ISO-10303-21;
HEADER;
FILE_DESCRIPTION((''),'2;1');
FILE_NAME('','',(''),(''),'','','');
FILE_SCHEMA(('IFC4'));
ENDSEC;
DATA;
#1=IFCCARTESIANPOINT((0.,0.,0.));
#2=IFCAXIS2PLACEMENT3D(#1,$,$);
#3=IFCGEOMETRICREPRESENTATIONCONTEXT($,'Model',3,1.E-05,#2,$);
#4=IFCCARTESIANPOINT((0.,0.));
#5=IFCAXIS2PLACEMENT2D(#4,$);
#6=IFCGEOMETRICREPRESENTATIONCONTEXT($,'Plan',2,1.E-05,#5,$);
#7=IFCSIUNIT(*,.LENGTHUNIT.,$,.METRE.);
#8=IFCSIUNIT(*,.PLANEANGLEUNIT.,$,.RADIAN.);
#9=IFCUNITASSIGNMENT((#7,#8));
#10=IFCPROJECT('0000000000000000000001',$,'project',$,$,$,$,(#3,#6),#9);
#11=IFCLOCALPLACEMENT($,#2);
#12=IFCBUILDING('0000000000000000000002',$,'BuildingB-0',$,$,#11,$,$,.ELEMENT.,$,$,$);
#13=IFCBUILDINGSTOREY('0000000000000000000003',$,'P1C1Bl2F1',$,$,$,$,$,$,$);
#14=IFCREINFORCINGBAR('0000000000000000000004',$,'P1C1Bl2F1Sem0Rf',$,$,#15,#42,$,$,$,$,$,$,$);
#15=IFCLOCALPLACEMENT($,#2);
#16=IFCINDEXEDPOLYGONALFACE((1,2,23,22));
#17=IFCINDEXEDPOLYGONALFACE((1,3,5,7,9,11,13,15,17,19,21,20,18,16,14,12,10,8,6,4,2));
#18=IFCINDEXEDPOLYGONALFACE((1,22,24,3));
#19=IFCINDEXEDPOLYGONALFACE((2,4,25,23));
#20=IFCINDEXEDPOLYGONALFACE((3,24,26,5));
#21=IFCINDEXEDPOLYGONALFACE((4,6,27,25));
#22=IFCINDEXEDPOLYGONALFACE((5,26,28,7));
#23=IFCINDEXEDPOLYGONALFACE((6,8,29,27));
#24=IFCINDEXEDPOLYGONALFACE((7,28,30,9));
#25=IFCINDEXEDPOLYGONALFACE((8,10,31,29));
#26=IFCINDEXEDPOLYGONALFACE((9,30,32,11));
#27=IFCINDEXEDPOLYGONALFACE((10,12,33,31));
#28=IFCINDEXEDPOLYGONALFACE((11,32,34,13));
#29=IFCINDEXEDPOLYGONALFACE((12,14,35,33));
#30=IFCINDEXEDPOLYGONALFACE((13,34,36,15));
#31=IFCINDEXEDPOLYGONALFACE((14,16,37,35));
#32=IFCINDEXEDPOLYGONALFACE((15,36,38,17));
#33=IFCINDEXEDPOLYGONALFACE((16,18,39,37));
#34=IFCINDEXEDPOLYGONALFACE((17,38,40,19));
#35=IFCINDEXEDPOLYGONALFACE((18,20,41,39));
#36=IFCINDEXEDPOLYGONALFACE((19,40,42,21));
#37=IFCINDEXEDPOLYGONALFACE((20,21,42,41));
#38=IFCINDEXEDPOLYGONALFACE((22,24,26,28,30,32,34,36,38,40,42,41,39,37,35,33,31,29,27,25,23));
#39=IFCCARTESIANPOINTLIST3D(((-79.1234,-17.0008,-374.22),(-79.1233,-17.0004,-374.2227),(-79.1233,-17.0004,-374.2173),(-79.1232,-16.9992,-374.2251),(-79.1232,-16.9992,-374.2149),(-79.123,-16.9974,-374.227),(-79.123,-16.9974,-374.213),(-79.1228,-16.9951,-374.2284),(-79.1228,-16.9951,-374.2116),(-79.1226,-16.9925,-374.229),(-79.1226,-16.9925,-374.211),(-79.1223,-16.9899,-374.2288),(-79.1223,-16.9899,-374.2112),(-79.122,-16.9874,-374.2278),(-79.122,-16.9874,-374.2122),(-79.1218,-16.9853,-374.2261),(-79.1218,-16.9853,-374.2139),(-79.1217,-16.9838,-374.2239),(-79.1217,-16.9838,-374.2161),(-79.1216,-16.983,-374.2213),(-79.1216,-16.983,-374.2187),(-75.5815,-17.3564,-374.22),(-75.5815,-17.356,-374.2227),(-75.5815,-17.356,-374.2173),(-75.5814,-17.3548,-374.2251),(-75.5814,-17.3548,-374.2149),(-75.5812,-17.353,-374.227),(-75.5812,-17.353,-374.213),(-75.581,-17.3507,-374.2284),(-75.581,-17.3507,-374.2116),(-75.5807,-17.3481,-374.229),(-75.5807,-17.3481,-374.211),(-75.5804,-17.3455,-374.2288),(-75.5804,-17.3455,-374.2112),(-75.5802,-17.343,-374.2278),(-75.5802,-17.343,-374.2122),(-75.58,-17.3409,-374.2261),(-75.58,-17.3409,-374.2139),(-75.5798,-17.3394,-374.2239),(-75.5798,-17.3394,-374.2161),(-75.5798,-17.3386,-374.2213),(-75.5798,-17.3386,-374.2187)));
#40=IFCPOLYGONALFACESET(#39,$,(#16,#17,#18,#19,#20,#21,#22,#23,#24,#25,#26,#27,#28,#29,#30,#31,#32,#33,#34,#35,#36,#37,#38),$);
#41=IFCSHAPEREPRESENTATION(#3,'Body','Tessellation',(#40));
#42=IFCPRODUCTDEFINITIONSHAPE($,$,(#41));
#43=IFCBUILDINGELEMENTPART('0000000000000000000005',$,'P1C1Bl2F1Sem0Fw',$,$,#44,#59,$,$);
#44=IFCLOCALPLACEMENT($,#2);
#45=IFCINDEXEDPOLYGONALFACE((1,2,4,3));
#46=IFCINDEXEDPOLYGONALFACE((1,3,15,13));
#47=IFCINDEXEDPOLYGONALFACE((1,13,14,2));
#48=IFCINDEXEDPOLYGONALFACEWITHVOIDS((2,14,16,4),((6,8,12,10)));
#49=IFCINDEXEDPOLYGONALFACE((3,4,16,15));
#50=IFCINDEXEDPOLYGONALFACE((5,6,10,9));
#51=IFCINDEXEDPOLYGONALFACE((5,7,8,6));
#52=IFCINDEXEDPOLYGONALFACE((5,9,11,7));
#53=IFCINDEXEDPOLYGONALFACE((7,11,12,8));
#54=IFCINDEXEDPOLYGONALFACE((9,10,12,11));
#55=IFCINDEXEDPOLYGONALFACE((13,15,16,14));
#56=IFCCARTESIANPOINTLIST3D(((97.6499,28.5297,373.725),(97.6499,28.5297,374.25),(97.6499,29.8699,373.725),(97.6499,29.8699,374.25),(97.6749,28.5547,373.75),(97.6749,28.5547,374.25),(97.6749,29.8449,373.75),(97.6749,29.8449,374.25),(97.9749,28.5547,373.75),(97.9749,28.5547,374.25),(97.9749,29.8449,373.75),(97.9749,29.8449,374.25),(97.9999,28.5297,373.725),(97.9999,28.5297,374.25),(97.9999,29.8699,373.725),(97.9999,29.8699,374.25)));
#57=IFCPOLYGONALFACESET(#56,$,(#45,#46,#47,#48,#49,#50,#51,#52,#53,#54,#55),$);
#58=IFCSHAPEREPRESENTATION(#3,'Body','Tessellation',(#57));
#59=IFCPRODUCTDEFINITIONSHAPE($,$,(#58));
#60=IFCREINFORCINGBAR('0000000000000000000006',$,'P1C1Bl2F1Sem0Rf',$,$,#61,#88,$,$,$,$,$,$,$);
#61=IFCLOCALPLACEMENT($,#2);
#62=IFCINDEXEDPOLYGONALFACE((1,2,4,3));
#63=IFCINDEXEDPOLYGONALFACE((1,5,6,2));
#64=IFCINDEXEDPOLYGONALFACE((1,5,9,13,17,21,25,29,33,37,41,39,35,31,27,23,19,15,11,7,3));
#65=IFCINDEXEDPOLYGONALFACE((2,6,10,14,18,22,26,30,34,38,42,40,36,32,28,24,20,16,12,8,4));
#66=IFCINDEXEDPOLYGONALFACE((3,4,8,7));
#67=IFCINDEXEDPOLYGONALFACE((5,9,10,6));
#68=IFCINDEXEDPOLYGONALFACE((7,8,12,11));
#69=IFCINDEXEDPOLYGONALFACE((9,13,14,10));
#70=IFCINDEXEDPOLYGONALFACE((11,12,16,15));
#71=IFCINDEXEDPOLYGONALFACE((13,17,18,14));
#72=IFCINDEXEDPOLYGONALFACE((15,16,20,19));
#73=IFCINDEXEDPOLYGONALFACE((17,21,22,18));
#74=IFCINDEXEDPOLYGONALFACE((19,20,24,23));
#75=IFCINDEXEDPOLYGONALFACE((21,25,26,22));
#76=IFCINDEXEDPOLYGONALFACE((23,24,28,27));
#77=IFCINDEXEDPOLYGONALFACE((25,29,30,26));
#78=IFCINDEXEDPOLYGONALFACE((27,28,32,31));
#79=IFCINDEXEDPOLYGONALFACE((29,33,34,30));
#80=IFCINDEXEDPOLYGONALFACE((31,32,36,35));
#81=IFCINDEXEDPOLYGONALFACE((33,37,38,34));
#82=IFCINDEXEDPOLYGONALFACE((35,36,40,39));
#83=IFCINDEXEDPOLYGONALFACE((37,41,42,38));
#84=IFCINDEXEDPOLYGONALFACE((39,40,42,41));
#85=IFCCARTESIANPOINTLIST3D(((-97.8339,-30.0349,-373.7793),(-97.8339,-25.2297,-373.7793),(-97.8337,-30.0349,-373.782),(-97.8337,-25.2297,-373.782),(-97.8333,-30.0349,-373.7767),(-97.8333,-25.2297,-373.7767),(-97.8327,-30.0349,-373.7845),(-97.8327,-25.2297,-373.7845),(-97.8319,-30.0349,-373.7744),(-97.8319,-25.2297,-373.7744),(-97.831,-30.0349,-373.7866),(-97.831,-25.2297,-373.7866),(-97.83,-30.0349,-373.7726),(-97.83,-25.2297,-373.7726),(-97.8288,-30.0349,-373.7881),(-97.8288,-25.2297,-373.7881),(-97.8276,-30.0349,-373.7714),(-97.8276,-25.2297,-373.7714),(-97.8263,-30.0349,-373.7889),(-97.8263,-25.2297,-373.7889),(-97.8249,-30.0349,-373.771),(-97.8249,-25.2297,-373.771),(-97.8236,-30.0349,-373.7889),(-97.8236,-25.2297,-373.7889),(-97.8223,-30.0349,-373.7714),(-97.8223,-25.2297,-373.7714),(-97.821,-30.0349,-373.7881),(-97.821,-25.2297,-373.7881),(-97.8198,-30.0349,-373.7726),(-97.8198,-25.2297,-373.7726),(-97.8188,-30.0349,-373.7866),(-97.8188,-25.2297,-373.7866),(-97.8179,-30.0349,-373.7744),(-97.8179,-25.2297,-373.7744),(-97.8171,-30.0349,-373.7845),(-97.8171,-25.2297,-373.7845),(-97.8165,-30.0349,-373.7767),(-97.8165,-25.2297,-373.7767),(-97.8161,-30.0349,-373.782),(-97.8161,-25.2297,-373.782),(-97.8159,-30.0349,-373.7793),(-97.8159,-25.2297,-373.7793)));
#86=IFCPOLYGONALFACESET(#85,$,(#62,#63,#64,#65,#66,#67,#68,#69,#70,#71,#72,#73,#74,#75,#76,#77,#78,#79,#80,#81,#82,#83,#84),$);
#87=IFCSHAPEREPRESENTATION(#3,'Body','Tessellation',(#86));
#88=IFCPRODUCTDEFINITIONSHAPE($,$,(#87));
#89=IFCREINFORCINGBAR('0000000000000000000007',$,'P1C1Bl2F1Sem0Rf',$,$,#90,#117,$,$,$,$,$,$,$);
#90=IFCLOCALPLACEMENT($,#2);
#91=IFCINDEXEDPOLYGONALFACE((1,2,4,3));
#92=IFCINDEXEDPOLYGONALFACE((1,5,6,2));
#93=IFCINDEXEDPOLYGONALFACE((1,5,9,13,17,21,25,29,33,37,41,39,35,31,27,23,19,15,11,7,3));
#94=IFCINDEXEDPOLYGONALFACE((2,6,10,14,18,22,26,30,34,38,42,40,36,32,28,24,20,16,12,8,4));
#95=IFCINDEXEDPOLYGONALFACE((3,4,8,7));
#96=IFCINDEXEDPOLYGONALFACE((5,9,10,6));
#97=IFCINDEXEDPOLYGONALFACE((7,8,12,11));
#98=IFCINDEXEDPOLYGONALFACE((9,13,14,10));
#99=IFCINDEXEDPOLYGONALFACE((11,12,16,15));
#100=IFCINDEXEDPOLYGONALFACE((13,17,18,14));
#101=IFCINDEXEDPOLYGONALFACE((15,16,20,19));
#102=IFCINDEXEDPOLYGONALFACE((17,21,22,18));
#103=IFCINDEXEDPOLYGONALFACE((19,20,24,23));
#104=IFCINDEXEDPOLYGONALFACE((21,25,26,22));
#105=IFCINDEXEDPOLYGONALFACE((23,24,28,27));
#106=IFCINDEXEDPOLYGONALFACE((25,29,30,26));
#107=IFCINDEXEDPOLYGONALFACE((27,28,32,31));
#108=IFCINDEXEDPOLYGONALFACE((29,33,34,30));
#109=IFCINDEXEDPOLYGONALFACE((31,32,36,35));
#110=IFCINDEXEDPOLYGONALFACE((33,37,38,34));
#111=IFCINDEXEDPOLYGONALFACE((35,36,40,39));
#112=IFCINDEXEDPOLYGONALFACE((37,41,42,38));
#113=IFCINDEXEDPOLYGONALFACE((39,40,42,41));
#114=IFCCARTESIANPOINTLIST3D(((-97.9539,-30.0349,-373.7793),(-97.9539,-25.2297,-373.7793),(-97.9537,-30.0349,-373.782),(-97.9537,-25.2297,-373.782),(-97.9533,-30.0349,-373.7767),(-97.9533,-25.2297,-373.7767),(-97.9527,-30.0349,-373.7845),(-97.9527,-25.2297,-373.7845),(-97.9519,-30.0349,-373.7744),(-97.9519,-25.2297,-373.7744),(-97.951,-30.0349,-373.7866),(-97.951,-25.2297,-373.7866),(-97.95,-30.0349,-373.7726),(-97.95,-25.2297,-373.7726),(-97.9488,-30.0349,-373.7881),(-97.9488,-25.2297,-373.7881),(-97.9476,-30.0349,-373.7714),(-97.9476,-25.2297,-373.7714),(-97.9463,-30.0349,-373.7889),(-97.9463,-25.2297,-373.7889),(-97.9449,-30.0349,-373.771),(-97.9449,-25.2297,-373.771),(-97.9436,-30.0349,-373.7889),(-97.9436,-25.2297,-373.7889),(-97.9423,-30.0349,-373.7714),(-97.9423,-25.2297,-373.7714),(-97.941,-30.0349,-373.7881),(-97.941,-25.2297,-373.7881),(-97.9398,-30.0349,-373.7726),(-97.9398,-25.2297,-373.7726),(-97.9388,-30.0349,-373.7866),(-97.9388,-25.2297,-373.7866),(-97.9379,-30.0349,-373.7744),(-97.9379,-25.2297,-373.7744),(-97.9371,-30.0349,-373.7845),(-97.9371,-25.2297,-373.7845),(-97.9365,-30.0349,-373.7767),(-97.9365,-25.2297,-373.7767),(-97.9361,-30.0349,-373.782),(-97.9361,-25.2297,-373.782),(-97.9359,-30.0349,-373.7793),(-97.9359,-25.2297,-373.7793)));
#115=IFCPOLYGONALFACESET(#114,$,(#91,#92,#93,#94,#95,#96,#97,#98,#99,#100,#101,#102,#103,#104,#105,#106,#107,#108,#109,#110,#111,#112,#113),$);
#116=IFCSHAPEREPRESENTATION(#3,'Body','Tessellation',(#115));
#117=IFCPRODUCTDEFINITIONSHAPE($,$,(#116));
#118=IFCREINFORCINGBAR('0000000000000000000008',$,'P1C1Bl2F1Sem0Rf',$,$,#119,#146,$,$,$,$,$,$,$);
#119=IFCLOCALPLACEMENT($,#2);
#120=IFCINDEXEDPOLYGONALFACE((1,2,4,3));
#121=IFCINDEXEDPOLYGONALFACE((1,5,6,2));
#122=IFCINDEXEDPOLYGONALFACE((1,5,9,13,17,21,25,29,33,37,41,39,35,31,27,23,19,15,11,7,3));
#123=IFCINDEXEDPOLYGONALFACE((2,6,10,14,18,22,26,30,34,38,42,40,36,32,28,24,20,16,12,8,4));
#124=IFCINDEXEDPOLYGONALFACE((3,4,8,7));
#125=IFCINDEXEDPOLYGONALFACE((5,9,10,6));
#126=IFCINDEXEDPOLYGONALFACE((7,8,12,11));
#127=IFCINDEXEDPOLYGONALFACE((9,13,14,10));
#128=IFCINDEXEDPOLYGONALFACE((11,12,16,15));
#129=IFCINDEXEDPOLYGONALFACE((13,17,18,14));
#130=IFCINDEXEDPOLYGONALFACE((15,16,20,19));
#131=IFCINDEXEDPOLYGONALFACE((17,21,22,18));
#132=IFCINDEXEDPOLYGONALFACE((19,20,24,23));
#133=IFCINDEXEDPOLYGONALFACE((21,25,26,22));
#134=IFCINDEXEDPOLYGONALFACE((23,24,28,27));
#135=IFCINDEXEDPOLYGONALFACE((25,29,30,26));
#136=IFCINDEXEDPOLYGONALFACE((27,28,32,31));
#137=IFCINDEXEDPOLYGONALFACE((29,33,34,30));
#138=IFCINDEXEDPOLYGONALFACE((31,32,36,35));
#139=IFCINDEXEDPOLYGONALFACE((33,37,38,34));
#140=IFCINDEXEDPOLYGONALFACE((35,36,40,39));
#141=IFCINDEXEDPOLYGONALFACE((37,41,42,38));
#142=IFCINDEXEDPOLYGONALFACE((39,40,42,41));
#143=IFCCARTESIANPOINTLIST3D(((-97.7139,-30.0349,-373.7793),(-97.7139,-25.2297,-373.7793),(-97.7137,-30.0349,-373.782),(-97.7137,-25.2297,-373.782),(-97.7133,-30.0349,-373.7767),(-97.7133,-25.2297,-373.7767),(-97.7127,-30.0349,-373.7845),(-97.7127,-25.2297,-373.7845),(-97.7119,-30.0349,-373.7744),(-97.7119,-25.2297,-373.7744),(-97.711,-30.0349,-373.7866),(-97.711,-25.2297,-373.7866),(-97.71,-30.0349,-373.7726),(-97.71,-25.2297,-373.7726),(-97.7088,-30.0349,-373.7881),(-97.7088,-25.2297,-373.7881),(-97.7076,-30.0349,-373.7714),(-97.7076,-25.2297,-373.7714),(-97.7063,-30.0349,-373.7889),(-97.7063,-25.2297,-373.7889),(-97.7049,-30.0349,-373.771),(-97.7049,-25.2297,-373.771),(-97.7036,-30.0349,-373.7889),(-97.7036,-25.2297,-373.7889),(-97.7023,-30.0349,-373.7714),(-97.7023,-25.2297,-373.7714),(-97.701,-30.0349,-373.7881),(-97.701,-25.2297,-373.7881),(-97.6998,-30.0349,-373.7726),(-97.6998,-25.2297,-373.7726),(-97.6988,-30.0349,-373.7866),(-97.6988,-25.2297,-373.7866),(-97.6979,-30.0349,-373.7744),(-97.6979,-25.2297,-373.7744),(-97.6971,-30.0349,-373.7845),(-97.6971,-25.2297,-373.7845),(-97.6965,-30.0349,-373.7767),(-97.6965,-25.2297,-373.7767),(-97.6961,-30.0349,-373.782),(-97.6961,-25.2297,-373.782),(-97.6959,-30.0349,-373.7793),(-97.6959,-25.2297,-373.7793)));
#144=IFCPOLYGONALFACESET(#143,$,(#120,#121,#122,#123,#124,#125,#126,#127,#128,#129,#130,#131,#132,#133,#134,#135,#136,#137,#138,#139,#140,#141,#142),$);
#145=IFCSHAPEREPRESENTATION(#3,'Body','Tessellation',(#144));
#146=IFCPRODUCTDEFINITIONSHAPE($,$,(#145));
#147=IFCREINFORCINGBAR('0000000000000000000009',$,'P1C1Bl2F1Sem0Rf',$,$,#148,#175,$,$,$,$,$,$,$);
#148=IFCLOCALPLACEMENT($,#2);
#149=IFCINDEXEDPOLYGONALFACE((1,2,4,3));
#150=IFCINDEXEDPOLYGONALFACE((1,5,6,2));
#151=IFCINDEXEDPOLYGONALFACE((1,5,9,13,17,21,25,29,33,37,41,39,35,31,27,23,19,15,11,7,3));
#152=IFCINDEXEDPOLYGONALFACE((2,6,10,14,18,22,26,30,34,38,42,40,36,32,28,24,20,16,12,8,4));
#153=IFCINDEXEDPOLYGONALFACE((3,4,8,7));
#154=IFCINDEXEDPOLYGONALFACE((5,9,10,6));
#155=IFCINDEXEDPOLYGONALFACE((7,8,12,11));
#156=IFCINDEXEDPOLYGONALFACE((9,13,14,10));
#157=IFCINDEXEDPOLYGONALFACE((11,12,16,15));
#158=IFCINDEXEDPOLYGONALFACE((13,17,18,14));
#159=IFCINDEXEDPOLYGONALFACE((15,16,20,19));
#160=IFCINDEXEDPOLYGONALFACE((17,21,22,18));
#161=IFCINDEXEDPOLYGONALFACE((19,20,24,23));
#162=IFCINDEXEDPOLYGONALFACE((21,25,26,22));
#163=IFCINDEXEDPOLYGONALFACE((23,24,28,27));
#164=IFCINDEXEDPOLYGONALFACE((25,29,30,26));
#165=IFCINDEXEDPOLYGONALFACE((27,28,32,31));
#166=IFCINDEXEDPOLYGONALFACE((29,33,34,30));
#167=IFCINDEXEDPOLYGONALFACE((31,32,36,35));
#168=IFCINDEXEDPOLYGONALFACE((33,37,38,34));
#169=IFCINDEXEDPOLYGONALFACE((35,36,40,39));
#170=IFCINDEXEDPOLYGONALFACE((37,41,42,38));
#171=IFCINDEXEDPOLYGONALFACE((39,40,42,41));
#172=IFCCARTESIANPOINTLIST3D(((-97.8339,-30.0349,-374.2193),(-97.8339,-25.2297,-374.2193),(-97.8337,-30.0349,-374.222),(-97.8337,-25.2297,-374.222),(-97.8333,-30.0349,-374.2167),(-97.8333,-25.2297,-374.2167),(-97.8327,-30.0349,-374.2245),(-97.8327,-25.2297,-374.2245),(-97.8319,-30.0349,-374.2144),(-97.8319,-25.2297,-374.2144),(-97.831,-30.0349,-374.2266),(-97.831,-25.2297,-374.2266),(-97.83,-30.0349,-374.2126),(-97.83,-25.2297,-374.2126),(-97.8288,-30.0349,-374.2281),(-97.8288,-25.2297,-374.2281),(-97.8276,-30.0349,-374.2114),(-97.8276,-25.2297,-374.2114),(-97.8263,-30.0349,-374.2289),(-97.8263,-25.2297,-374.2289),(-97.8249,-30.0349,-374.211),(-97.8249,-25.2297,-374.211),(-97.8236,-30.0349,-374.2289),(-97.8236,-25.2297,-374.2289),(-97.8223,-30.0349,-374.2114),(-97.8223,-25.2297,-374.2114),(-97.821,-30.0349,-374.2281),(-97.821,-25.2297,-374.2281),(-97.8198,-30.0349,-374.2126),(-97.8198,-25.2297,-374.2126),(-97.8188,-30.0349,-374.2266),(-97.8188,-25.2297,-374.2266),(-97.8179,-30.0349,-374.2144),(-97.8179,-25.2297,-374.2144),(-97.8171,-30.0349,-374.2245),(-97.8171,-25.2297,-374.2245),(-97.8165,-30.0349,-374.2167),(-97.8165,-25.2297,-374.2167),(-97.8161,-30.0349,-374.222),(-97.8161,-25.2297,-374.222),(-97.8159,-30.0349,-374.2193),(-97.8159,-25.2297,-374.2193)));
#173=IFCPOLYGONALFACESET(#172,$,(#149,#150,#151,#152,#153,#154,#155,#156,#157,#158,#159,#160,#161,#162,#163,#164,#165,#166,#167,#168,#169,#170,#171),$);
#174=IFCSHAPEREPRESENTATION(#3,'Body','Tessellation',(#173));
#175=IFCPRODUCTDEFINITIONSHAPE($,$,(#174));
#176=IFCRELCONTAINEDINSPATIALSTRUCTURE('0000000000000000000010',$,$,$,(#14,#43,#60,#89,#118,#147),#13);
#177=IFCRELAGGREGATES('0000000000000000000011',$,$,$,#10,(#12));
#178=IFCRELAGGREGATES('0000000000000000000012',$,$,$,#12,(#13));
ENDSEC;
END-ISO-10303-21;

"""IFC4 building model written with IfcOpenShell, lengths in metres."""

from ifc_helpers import new_model, entity, si_unit, origin, origin_2d, place, context, project, spatial, polyline, outline, extrude, element, save


model = new_model("IFC4")

# Units and contexts
model_context = context("Model", 3, precision=1e-05, world=origin())
plan_context = context("Plan", 2, precision=1e-05, world=origin_2d())
ifc_project = project(units=[si_unit("LENGTHUNIT", "METRE"), si_unit("PLANEANGLEUNIT", "RADIAN")], contexts=[model_context, plan_context])

# Building, storey
building_placement = place(None, origin())
building = spatial("IfcBuilding", under=ifc_project, at=building_placement, Name="BuildingB-0", CompositionType="ELEMENT")
storey = spatial("IfcBuildingStorey", under=building, Name="P1C1Bl2F1")

# Reinforcing bar
element("IfcReinforcingBar", 1, inside=storey, Name="P1C1Bl2F1Sem0Rf", context=model_context, shape_type="SweptSolid", body=[
    entity("IfcSurfaceCurveSweptAreaSolid", entity("IfcCircleProfileDef", "AREA", None, None, 0.009), None, entity("IfcPolyline", [entity("IfcCartesianPoint", [79.1225, 16.9918, 374.22]), entity("IfcCartesianPoint", [75.5806, 17.3474, 374.22])]), None, None, entity("IfcPlane", entity("IfcAxis2Placement3D", entity("IfcCartesianPoint", [79.1225, 16.9918, 374.22]), entity("IfcDirection", [0.0, 0.0, 1.0]), entity("IfcDirection", [1.0, 0.0, 0.0])))),
])

# Building element part, opening
building_element_part_1 = element("IfcBuildingElementPart", 2, inside=storey, Name="P1C1Bl2F1Sem0Fw", context=model_context, shape_type="SweptSolid", body=[
    extrude(outline(polyline([(97.9999, 28.5297, 373.725), (97.6499, 28.5297, 373.725), (97.6499, 29.8699, 373.725), (97.9999, 29.8699, 373.725), (97.9999, 28.5297, 373.725)])), None, (0.0, 0.0, 1.0), 0.525),
])
element("IfcOpeningElement", 3, inside=storey, cuts=building_element_part_1, context=model_context, shape_type="SweptSolid", body=[
    extrude(outline(polyline([(97.9749, 28.5547, 373.75), (97.6749, 28.5547, 373.75), (97.6749, 29.8449, 373.75), (97.9749, 29.8449, 373.75), (97.9749, 28.5547, 373.75)])), None, (0.0, 0.0, 1.0), 0.5),
])

# Reinforcing bars
element("IfcReinforcingBar", 4, inside=storey, Name="P1C1Bl2F1Sem0Rf", context=model_context, shape_type="SweptSolid", body=[
    entity("IfcSurfaceCurveSweptAreaSolid", entity("IfcCircleProfileDef", "AREA", None, None, 0.009), None, entity("IfcPolyline", [entity("IfcCartesianPoint", [97.8249, 25.2297, 373.78]), entity("IfcCartesianPoint", [97.8249, 30.0349, 373.78])]), None, None, entity("IfcPlane", entity("IfcAxis2Placement3D", entity("IfcCartesianPoint", [97.8249, 25.2297, 373.78]), entity("IfcDirection", [0.0, 0.0, 1.0]), entity("IfcDirection", [1.0, 0.0, 0.0])))),
])
element("IfcReinforcingBar", 5, inside=storey, Name="P1C1Bl2F1Sem0Rf", context=model_context, shape_type="SweptSolid", body=[
    entity("IfcSurfaceCurveSweptAreaSolid", entity("IfcCircleProfileDef", "AREA", None, None, 0.009), None, entity("IfcPolyline", [entity("IfcCartesianPoint", [97.9449, 25.2297, 373.78]), entity("IfcCartesianPoint", [97.9449, 30.0349, 373.78])]), None, None, entity("IfcPlane", entity("IfcAxis2Placement3D", entity("IfcCartesianPoint", [97.9449, 25.2297, 373.78]), entity("IfcDirection", [0.0, 0.0, 1.0]), entity("IfcDirection", [1.0, 0.0, 0.0])))),
])
element("IfcReinforcingBar", 6, inside=storey, Name="P1C1Bl2F1Sem0Rf", context=model_context, shape_type="SweptSolid", body=[
    entity("IfcSurfaceCurveSweptAreaSolid", entity("IfcCircleProfileDef", "AREA", None, None, 0.009), None, entity("IfcPolyline", [entity("IfcCartesianPoint", [97.7049, 25.2297, 373.78]), entity("IfcCartesianPoint", [97.7049, 30.0349, 373.78])]), None, None, entity("IfcPlane", entity("IfcAxis2Placement3D", entity("IfcCartesianPoint", [97.7049, 25.2297, 373.78]), entity("IfcDirection", [0.0, 0.0, 1.0]), entity("IfcDirection", [1.0, 0.0, 0.0])))),
])
element("IfcReinforcingBar", 7, inside=storey, Name="P1C1Bl2F1Sem0Rf", context=model_context, shape_type="SweptSolid", body=[
    entity("IfcSurfaceCurveSweptAreaSolid", entity("IfcCircleProfileDef", "AREA", None, None, 0.009), None, entity("IfcPolyline", [entity("IfcCartesianPoint", [97.8249, 25.2297, 374.22]), entity("IfcCartesianPoint", [97.8249, 30.0349, 374.22])]), None, None, entity("IfcPlane", entity("IfcAxis2Placement3D", entity("IfcCartesianPoint", [97.8249, 25.2297, 374.22]), entity("IfcDirection", [0.0, 0.0, 1.0]), entity("IfcDirection", [1.0, 0.0, 0.0])))),
])

save(model, "model.ifc")
